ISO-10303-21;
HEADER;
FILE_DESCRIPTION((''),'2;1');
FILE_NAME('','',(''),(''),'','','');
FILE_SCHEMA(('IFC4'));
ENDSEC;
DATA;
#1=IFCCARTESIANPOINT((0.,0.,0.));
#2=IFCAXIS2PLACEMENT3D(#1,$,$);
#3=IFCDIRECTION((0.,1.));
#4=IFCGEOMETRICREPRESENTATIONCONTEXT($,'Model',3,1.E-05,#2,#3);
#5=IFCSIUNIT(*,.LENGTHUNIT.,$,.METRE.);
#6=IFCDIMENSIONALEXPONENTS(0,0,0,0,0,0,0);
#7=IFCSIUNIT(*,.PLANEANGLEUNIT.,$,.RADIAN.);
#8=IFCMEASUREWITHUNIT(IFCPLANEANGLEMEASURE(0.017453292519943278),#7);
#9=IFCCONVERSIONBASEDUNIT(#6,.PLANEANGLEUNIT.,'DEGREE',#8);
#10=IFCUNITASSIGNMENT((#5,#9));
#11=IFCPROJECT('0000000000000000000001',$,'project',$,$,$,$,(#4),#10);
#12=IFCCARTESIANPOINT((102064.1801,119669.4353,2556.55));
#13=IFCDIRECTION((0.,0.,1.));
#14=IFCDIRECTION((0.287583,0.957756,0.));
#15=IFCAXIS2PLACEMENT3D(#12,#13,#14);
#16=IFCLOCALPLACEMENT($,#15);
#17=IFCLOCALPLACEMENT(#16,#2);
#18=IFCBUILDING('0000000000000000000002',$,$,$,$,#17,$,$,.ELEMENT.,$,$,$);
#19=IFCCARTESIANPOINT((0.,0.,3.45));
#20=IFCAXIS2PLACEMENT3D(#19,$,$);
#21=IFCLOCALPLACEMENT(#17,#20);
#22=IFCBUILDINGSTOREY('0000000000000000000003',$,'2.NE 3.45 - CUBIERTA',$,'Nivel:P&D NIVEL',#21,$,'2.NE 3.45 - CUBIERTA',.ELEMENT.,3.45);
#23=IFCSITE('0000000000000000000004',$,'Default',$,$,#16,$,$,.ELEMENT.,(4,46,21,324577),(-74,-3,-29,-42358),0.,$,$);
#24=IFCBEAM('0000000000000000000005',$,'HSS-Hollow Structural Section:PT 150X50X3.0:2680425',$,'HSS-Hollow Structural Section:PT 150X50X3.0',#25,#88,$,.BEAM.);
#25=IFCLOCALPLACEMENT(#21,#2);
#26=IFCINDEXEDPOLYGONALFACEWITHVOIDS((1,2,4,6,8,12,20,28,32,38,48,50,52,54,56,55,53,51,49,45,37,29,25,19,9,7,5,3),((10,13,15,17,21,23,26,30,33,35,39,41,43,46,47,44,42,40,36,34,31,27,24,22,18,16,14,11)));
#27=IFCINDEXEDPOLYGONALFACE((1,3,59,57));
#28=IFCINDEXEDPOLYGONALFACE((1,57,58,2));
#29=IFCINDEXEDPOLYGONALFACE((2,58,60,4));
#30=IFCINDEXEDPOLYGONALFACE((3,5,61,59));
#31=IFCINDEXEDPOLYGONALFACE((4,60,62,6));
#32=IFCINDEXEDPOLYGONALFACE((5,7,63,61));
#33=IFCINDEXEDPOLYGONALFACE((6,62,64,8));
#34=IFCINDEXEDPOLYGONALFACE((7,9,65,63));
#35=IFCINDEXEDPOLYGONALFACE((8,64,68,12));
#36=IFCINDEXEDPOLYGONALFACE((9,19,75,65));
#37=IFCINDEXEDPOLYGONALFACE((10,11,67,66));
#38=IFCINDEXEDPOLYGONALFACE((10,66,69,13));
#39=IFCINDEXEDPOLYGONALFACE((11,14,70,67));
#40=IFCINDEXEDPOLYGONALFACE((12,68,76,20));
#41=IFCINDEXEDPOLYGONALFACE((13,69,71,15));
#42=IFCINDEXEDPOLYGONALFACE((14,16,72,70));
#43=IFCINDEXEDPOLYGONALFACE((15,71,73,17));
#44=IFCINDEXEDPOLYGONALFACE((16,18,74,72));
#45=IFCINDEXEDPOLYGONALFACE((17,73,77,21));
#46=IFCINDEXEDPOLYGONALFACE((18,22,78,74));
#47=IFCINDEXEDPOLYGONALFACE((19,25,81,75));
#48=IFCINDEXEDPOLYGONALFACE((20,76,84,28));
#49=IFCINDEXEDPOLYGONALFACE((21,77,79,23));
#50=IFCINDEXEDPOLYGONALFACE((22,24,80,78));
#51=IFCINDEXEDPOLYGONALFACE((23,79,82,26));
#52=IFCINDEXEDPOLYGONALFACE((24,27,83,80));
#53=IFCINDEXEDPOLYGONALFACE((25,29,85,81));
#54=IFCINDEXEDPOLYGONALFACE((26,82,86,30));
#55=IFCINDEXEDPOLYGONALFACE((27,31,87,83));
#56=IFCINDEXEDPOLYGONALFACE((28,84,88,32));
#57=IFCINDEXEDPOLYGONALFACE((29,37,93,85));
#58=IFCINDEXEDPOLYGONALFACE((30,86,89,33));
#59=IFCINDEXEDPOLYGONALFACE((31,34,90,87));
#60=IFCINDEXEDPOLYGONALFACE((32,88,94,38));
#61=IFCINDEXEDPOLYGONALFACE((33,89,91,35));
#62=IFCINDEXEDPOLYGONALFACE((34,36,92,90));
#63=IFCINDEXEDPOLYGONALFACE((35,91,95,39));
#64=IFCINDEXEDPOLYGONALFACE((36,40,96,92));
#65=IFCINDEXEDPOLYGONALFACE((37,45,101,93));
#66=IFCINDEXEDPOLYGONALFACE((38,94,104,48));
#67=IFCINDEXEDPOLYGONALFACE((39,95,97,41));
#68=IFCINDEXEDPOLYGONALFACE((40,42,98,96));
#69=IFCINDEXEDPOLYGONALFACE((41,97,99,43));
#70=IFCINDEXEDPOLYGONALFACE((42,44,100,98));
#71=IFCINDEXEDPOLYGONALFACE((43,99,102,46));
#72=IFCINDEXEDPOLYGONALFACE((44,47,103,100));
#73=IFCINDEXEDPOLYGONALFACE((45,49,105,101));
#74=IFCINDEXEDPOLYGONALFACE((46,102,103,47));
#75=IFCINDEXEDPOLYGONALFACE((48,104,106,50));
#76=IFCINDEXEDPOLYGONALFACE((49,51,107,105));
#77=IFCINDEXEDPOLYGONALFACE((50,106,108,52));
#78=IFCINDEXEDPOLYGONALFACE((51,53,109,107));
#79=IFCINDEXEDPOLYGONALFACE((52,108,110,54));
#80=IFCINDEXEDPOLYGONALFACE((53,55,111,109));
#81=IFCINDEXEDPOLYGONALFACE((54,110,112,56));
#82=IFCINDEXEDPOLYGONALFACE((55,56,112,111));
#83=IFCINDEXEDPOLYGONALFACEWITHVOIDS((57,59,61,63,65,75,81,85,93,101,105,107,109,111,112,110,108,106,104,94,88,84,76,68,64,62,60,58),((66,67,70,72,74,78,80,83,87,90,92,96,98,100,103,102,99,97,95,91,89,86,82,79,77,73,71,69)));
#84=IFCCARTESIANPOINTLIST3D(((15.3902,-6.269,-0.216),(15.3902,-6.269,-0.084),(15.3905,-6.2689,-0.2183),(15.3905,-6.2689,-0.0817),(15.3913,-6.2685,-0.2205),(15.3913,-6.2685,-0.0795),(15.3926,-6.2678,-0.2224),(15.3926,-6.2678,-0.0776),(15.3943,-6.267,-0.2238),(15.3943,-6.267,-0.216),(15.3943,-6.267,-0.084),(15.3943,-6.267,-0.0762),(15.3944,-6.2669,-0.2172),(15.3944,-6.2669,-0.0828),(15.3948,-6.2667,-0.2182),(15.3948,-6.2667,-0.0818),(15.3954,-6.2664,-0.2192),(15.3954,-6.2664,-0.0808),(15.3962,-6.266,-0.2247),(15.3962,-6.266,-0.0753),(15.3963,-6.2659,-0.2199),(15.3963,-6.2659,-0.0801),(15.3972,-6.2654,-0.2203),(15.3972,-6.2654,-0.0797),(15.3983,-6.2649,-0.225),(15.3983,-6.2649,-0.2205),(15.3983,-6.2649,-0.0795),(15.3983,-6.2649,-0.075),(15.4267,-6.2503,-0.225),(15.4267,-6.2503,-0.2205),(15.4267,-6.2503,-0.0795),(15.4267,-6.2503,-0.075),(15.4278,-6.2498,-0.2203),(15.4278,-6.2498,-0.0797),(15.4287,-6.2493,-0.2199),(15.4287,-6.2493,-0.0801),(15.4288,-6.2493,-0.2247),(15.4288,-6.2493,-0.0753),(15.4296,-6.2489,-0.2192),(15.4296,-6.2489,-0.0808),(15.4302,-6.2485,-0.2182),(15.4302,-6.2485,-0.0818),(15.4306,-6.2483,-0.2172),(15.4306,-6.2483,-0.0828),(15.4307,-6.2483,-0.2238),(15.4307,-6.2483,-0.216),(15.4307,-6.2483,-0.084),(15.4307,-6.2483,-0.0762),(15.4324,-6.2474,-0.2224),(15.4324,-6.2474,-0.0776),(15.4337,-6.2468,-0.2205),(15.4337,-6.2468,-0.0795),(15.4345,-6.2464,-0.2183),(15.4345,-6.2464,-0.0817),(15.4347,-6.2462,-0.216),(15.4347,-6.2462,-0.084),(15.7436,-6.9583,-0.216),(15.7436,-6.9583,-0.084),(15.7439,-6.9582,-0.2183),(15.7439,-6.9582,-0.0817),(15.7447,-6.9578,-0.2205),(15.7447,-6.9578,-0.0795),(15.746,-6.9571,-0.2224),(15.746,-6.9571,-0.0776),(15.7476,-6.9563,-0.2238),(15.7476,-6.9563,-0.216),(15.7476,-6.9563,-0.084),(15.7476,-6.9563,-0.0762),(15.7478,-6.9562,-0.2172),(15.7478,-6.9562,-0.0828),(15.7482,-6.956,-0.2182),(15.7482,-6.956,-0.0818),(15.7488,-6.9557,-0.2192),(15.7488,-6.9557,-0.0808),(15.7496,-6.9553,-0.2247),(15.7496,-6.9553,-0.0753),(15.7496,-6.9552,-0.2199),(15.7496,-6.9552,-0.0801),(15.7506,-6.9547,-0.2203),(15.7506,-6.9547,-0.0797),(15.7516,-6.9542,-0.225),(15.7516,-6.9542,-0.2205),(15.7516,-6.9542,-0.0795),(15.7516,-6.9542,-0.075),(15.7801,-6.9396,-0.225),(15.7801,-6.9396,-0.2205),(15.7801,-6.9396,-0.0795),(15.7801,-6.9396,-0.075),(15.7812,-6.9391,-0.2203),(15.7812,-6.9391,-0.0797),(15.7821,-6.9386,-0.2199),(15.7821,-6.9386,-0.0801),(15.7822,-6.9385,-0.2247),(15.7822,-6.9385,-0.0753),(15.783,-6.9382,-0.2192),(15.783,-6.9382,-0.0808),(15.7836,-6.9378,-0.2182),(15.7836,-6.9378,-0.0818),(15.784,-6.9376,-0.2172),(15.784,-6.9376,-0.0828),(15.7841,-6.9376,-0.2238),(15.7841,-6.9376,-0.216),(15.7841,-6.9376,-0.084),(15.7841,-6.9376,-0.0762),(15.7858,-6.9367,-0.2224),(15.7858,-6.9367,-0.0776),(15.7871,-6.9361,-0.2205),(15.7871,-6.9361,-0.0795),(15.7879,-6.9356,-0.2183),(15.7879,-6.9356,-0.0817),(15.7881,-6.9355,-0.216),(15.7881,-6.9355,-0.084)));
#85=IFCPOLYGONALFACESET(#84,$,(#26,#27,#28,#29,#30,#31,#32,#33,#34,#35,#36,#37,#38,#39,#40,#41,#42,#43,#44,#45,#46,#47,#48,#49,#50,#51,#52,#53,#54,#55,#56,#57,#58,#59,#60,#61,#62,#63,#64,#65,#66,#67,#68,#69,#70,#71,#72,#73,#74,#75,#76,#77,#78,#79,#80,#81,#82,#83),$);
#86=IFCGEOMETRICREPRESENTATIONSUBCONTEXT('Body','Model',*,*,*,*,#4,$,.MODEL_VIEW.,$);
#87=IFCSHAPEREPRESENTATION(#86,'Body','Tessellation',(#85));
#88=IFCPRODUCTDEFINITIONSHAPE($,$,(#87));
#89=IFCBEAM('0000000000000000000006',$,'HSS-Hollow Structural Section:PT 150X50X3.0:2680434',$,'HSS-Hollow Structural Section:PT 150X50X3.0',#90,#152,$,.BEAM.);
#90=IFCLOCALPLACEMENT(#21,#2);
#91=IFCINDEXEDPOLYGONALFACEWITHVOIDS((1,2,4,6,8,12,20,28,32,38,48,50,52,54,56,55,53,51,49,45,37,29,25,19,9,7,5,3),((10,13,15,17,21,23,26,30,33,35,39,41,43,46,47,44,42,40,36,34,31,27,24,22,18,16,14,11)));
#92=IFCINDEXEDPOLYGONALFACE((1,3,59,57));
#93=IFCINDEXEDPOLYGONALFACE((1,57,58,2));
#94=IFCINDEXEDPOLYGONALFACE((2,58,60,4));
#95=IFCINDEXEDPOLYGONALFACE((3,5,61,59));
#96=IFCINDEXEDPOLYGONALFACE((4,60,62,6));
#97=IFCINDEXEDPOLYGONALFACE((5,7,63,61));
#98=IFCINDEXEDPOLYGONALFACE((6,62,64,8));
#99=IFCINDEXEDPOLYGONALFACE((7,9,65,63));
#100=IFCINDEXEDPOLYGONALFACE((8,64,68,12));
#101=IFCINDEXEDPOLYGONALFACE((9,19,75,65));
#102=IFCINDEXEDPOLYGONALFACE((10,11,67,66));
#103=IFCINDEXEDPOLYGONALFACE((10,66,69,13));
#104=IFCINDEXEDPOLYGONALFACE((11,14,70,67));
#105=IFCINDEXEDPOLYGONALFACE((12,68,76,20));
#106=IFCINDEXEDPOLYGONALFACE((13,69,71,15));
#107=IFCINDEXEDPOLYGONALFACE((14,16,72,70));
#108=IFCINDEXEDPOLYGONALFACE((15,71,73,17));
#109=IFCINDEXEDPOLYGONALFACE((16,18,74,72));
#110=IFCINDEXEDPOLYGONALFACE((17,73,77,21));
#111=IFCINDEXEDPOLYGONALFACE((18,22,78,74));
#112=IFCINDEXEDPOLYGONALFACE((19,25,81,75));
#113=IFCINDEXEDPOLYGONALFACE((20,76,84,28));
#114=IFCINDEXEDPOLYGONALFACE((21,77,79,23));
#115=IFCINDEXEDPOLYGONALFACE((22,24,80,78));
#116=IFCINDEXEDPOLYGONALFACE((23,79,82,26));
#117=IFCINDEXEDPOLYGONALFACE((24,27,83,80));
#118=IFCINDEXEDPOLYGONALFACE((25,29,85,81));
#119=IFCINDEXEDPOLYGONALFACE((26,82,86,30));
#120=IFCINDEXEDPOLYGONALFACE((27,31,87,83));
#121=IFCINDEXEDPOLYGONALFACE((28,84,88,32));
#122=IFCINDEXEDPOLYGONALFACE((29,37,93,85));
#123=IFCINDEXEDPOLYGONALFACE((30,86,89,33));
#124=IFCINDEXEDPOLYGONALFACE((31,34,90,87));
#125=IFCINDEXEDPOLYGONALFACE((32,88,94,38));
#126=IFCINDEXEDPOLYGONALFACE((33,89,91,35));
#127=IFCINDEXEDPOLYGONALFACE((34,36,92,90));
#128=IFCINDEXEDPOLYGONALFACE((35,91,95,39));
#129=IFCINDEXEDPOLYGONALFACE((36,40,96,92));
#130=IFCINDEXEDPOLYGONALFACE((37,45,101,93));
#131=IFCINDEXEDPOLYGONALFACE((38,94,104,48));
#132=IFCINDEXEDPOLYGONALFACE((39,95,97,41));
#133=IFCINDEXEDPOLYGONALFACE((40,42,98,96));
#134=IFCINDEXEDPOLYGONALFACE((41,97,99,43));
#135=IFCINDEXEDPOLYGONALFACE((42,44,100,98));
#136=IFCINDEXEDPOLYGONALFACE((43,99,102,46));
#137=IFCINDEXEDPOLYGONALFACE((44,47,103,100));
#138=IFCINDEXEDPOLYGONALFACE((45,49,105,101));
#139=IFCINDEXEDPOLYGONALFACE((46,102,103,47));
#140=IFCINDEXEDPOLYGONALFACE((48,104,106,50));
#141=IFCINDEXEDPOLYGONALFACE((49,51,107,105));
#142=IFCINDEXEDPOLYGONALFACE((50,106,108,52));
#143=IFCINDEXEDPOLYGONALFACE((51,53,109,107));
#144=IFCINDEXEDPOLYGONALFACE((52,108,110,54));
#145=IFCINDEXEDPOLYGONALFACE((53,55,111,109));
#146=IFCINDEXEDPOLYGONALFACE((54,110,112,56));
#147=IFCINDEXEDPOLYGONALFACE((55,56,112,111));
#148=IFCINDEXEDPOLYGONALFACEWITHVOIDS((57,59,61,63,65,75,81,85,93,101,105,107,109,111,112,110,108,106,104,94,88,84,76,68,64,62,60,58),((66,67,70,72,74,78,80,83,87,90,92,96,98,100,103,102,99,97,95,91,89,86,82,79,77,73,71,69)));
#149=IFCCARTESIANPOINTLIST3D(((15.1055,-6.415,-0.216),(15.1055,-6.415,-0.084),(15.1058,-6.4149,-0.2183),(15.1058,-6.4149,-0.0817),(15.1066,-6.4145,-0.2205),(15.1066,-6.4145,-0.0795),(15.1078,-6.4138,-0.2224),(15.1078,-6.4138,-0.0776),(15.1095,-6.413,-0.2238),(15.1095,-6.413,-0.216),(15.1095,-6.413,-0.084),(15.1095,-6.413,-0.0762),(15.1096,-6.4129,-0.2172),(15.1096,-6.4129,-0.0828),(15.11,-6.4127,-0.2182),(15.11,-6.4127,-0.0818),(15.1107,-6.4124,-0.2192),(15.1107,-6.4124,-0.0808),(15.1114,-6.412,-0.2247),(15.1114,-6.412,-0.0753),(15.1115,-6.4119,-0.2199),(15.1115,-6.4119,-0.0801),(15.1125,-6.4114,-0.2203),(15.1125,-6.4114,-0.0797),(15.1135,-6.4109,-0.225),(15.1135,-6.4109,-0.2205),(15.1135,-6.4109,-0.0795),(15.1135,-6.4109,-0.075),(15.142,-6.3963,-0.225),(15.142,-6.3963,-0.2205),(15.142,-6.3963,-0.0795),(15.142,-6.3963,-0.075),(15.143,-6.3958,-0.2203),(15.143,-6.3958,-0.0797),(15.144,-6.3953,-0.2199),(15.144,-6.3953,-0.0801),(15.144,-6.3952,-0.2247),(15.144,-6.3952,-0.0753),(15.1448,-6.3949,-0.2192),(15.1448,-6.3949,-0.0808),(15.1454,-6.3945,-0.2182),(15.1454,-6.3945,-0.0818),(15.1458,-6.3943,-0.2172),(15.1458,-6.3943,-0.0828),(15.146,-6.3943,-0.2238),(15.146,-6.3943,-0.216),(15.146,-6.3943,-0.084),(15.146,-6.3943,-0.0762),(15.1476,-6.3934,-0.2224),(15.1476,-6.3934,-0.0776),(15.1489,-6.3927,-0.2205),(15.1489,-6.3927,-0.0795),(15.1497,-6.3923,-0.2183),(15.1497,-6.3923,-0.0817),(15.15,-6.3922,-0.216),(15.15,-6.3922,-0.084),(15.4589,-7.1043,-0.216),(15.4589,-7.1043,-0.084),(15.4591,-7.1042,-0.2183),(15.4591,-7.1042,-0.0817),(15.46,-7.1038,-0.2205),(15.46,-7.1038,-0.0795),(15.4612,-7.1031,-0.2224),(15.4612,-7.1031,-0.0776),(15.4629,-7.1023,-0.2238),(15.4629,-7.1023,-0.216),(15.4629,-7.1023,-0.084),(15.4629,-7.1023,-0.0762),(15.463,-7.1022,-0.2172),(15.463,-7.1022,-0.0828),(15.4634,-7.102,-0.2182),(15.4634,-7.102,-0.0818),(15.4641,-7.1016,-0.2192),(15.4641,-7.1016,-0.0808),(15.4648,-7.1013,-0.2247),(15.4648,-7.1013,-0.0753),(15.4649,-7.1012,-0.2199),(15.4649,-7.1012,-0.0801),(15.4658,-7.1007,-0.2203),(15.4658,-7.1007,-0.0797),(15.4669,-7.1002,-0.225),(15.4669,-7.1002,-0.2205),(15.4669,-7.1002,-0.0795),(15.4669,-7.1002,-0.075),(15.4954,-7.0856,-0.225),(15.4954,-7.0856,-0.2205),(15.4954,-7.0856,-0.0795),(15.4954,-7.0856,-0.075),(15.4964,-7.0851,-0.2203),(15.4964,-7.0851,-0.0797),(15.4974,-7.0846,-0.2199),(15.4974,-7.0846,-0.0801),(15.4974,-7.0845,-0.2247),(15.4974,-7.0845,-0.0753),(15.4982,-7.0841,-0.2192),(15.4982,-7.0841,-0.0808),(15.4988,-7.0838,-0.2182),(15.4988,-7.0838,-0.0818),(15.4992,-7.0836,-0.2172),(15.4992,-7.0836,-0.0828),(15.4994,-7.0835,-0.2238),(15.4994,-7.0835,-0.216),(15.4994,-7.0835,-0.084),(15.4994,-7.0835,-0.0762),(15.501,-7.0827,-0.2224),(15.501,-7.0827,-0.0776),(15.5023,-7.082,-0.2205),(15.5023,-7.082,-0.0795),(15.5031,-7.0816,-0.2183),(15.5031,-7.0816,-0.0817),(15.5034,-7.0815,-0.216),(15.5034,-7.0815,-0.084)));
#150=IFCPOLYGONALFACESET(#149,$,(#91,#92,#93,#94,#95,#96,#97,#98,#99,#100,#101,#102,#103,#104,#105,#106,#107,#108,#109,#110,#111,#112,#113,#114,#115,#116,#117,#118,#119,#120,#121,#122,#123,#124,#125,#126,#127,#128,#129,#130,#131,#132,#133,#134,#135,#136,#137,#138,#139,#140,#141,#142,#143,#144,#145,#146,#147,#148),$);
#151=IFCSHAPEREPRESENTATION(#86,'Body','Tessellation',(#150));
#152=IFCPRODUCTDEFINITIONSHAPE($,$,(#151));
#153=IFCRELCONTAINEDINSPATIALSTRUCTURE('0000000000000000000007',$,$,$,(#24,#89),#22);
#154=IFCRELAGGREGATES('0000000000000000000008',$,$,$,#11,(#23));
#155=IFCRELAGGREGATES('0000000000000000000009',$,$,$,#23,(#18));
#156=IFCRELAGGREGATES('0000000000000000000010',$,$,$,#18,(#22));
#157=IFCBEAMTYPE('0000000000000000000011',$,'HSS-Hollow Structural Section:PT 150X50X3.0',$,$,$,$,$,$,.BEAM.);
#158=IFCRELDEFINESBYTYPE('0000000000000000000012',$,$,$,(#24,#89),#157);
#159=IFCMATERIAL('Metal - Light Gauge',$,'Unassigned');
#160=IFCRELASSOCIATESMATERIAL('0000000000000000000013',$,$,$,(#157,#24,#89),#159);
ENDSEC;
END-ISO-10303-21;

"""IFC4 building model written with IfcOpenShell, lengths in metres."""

from ifc_helpers import new_model, entity, si_unit, converted_unit, direction, frame, origin, place, context, subcontext, project, spatial, line, arc, indexed_curve, outline, extrude, source, transform, mapped, material, type_object, type_shapes, element, save


model = new_model("IFC4")

# Units and contexts
model_context = context("Model", 3, precision=1e-05, world=origin(), true_north=direction((0.0, 1.0)))
body_context = subcontext(model_context, "Body", "Model", "MODEL_VIEW")
ifc_project = project(units=[si_unit("LENGTHUNIT", "METRE"), converted_unit("PLANEANGLEUNIT", "DEGREE", entity("IfcPlaneAngleMeasure", 0.017453292519943278), si_unit("PLANEANGLEUNIT", "RADIAN"), dimensions=[0, 0, 0, 0, 0, 0, 0])], contexts=[model_context])

# Site, building, storey
site_placement = place(None, frame((102064.1801, 119669.4353, 2556.55), z_axis=(0.0, 0.0, 1.0), x_axis=(0.287583, 0.957756, 0.0)))
site = spatial("IfcSite", under=ifc_project, at=site_placement, Name="Default", CompositionType="ELEMENT", RefLatitude=(4, 46, 21, 324577), RefLongitude=(-74, -3, -29, -42358), RefElevation=0.0)
building_placement = place(site_placement, origin())
building = spatial("IfcBuilding", under=site, at=building_placement, CompositionType="ELEMENT")
storey_placement = place(building_placement, frame((0.0, 0.0, 3.45)))
storey = spatial("IfcBuildingStorey", under=building, at=storey_placement, Name="2.NE 3.45 - CUBIERTA", ObjectType="Nivel:P&D NIVEL", LongName="2.NE 3.45 - CUBIERTA", CompositionType="ELEMENT", Elevation=3.45)

# Beams
ifc_material_1 = material(Name="Metal - Light Gauge", Category="Unassigned")
beam_type_1 = type_object("IfcBeamType", Name="HSS-Hollow Structural Section:PT 150X50X3.0", PredefinedType="BEAM", material=ifc_material_1)
shared_shape_1 = source(origin(), body_context, "Body", "SweptSolid", [
    extrude(outline(indexed_curve([(-0.025, -0.066), (-0.0224, -0.0724), (-0.016, -0.075), (0.016, -0.075), (0.0224, -0.0724), (0.025, -0.066), (0.025, 0.066), (0.0224, 0.0724), (0.016, 0.075), (-0.016, 0.075), (-0.0224, 0.0724), (-0.025, 0.066)], segments=[arc(1, 2, 3), line(3, 4), arc(4, 5, 6), line(6, 7), arc(7, 8, 9), line(9, 10), arc(10, 11, 12), line(12, 1)], self_intersect=False), holes=[indexed_curve([(0.016, -0.0705), (-0.016, -0.0705), (-0.0192, -0.0692), (-0.0205, -0.066), (-0.0205, 0.066), (-0.0192, 0.0692), (-0.016, 0.0705), (0.016, 0.0705), (0.0192, 0.0692), (0.0205, 0.066), (0.0205, -0.066), (0.0192, -0.0692)], segments=[line(1, 2), arc(2, 3, 4), line(4, 5), arc(5, 6, 7), line(7, 8), arc(8, 9, 10), line(10, 11), arc(11, 12, 1)], self_intersect=False)]), frame((-0.3873, 0.0, 0.0), z_axis=(1.0, 0.0, 0.0), x_axis=(0.0, -1.0, 0.0)), (0.0, 0.0, 1.0), 0.7746),
])
type_shapes(beam_type_1, [shared_shape_1])
for number, where, z_axis, x_axis, name in (
    (1, (15.5892, -6.6023, -0.15), (0.0, 0.0, 1.0), (-0.456217, 0.889869, 0.0), "HSS-Hollow Structural Section:PT 150X50X3.0:2680425"),
    (2, (15.3044, -6.7483, -0.15), (0.0, 0.0, 1.0), (-0.456217, 0.889869, 0.0), "HSS-Hollow Structural Section:PT 150X50X3.0:2680434"),
):
    element("IfcBeam", number, at=place(storey_placement, frame(where, z_axis=z_axis, x_axis=x_axis)), inside=storey, type_object=beam_type_1, material=ifc_material_1, Name=name, ObjectType="HSS-Hollow Structural Section:PT 150X50X3.0", PredefinedType="BEAM", context=body_context, shape_type="MappedRepresentation", body=[
        mapped(shared_shape_1, transform((0.0, 0.0, 0.0), scale=1.0)),
    ])

save(model, "model.ifc")
